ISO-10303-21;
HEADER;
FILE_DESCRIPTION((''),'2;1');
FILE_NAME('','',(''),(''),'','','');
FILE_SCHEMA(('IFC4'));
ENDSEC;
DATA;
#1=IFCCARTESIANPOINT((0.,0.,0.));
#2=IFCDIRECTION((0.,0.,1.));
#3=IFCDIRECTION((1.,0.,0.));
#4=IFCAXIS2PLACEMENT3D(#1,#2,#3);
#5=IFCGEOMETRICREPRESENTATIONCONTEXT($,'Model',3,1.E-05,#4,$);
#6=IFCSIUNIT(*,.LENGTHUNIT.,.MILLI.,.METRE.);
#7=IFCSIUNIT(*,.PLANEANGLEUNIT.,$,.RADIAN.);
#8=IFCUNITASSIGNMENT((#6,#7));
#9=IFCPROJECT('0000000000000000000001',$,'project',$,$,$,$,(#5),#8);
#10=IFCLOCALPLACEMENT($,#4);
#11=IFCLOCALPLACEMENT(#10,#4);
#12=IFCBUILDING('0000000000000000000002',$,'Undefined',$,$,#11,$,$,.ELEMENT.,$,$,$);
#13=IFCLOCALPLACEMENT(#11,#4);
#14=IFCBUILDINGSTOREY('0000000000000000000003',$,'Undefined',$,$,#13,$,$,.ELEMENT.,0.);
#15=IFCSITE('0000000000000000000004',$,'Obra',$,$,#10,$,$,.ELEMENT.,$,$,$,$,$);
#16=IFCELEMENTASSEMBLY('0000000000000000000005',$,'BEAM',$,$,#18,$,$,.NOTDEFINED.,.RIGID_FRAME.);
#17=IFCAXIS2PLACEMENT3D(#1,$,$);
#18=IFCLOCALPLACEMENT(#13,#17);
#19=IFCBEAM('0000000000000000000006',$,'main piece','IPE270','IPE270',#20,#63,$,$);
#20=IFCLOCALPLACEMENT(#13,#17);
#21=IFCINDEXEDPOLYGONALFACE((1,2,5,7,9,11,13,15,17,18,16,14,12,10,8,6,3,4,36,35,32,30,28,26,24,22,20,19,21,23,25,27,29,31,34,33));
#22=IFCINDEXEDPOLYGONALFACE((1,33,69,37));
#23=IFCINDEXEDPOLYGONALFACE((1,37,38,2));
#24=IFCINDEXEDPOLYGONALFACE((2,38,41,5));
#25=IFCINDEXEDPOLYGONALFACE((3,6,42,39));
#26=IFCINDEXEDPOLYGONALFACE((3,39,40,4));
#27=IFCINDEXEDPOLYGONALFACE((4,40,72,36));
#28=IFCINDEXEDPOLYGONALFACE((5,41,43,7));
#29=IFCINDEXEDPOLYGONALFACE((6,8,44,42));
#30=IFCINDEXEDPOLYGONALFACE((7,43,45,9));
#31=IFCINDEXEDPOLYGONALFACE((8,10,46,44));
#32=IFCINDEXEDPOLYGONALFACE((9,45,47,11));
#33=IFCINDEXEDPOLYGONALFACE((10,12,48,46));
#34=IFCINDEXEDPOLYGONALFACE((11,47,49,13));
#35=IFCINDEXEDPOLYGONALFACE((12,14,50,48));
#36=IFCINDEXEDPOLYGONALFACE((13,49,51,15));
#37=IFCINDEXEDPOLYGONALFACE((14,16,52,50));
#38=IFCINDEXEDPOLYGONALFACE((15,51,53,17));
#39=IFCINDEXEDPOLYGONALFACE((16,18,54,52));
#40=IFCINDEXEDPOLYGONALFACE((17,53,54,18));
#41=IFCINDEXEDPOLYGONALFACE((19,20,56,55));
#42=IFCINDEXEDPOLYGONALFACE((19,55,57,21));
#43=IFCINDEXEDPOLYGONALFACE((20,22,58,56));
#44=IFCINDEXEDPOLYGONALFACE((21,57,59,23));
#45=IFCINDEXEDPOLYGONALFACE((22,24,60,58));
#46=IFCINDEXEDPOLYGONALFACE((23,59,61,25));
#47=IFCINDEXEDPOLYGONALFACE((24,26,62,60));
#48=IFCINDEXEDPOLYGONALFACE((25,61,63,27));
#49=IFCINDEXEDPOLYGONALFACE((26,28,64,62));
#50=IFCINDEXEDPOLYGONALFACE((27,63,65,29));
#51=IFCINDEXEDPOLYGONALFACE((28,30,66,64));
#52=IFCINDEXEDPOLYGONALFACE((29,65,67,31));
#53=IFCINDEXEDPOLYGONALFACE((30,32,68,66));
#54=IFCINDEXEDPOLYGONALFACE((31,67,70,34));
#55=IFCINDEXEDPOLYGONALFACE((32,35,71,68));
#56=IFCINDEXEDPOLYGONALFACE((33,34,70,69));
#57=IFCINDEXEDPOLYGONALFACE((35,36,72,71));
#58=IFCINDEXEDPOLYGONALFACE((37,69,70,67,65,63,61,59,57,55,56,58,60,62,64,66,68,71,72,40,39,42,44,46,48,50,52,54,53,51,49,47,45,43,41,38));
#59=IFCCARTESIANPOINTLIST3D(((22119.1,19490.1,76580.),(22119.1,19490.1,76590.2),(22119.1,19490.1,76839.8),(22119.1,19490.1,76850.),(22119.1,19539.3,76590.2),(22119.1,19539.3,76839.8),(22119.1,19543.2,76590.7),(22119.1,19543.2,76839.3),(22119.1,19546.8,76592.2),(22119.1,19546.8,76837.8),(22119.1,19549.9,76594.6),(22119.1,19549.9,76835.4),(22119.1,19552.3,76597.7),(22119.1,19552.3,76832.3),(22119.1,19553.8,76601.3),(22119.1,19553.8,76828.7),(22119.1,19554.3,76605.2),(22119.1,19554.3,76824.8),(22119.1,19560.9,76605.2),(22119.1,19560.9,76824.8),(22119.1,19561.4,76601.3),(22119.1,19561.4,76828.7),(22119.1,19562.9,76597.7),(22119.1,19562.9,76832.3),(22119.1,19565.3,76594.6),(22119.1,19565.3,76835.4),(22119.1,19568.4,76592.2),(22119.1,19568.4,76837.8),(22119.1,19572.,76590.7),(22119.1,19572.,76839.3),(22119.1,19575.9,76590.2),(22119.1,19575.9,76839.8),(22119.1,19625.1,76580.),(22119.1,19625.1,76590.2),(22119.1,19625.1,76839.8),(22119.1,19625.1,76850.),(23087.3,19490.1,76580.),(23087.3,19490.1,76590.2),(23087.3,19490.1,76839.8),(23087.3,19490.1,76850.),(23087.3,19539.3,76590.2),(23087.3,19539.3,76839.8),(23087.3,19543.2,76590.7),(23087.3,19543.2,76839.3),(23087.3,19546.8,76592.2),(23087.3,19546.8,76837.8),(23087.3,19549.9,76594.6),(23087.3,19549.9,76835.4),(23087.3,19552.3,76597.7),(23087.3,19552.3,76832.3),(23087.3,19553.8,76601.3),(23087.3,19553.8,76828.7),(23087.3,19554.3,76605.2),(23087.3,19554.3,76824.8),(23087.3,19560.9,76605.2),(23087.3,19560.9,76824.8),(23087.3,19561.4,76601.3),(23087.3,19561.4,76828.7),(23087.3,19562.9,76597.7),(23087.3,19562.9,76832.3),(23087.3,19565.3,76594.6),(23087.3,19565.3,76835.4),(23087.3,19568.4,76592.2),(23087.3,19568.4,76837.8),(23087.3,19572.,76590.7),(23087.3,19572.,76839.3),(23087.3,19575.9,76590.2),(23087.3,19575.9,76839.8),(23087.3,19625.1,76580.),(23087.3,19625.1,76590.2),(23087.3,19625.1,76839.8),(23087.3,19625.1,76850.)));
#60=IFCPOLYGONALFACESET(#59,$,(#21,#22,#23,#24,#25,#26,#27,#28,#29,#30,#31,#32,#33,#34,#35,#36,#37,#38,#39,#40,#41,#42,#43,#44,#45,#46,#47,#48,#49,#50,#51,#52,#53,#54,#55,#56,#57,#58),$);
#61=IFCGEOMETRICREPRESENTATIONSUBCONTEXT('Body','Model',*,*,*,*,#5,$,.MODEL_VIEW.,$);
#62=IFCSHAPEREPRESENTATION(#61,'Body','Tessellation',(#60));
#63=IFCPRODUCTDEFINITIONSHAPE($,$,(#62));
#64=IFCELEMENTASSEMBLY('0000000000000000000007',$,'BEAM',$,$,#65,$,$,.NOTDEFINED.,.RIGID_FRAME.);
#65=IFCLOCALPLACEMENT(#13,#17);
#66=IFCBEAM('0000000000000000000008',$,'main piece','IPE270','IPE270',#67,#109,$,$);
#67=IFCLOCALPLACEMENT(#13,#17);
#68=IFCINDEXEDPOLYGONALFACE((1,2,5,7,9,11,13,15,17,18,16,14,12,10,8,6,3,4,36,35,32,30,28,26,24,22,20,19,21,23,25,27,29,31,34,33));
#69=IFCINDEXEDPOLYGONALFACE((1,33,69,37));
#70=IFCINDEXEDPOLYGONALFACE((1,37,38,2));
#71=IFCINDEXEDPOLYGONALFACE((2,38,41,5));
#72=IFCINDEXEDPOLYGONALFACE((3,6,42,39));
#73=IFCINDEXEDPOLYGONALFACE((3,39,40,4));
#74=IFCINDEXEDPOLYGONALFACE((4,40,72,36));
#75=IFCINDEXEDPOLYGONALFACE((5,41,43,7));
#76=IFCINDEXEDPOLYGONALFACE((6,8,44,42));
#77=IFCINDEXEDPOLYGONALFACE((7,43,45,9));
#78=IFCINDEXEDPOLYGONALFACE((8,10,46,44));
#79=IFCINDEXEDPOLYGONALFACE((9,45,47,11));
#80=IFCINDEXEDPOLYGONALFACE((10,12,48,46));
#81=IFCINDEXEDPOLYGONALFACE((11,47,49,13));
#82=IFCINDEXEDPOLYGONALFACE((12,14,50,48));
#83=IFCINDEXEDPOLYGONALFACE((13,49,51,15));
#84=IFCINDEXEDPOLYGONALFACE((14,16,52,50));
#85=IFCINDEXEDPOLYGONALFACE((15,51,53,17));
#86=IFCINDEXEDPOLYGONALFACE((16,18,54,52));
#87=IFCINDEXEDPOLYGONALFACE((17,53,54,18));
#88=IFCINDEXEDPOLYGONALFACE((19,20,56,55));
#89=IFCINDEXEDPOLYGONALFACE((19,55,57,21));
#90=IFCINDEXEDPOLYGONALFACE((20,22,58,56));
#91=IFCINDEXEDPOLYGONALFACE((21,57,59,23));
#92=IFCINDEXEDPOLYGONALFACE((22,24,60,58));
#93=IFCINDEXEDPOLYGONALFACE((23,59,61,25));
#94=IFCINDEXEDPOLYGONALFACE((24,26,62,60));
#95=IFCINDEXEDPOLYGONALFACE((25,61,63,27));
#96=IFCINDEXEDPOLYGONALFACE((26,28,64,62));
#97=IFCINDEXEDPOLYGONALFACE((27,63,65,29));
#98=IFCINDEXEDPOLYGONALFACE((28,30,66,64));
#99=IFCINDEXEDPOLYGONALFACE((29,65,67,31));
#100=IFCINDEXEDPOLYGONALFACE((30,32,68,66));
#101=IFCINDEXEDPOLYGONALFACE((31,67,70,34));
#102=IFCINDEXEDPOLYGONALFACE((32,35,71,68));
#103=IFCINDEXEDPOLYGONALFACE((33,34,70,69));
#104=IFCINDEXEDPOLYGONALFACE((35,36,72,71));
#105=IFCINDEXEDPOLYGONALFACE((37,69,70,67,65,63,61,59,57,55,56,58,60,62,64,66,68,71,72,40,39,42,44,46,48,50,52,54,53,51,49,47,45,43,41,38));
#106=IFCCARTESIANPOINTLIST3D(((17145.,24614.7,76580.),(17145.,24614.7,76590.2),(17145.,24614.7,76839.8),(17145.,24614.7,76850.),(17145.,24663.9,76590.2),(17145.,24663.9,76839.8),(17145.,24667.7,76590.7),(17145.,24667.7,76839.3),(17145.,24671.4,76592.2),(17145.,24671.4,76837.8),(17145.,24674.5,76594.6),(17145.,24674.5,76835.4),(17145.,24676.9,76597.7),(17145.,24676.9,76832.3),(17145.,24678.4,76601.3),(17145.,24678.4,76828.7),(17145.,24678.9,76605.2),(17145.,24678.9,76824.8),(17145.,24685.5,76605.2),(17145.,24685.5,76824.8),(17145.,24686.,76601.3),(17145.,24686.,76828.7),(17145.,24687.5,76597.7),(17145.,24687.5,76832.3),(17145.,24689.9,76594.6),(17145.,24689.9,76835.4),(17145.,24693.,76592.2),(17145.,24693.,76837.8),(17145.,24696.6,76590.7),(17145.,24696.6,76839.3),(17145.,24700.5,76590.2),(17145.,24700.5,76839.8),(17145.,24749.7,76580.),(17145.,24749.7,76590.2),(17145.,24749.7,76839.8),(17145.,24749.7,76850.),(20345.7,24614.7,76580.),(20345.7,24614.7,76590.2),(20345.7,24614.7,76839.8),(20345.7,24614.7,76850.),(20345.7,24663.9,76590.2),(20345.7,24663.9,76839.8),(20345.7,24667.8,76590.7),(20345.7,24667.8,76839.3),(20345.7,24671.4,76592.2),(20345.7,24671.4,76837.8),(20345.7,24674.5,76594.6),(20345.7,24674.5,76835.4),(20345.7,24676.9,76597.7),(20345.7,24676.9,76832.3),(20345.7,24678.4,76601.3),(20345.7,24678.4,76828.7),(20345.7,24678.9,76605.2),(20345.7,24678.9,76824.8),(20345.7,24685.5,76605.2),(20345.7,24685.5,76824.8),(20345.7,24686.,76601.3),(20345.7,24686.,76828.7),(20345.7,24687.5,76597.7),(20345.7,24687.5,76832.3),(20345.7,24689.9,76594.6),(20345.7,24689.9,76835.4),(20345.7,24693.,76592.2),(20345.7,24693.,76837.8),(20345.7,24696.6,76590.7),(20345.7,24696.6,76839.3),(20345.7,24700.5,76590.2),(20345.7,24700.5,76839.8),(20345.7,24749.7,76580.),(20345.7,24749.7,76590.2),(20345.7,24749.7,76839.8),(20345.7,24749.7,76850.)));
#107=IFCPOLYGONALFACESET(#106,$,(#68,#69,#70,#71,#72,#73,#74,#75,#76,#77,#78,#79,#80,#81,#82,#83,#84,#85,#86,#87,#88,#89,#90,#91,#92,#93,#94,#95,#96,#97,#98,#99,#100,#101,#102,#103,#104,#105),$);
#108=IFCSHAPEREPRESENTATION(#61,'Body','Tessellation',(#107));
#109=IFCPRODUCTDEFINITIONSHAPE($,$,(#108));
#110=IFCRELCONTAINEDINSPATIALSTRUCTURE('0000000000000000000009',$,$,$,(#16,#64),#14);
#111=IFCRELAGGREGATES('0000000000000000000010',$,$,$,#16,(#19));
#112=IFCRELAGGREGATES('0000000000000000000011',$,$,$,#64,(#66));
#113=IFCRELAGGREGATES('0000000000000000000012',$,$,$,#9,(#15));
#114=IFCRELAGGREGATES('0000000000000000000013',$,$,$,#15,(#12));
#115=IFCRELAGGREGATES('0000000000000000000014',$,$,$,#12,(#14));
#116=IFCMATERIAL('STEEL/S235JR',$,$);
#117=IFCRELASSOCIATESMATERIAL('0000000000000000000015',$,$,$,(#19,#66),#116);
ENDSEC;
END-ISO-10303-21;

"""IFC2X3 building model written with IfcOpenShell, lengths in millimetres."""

from ifc_helpers import new_model, si_unit, frame, origin_with_axes, origin_2d_with_axis, place, context, subcontext, project, spatial, i_section, extrude, material, element, aggregate, save


model = new_model("IFC2X3")

# Units and contexts
model_context = context("Model", 3, precision=1e-05, world=origin_with_axes())
body_context = subcontext(model_context, "Body", "Model", "MODEL_VIEW")
ifc_project = project(units=[si_unit("LENGTHUNIT", "METRE", prefix="MILLI"), si_unit("PLANEANGLEUNIT", "RADIAN")], contexts=[model_context])

# Site, building, storey
site_placement = place(None, origin_with_axes())
site = spatial("IfcSite", under=ifc_project, at=site_placement, Name="Obra", CompositionType="ELEMENT")
building_placement = place(site_placement, origin_with_axes())
building = spatial("IfcBuilding", under=site, at=building_placement, Name="Undefined", CompositionType="ELEMENT")
storey_placement = place(building_placement, origin_with_axes())
storey = spatial("IfcBuildingStorey", under=building, at=storey_placement, Name="Undefined", CompositionType="ELEMENT", Elevation=0.0)

# Element assemblies, beams
assembly_1_placement = place(storey_placement, origin_with_axes())
assembly_1 = element("IfcElementAssembly", 1, at=assembly_1_placement, inside=storey, Name="BEAM", AssemblyPlace="NOTDEFINED", PredefinedType="RIGID_FRAME")
ifc_material = material(Name="STEEL/S235JR")
beam_1_placement = place(assembly_1_placement, frame((22119.1, 19557.6, 76715.0), z_axis=(0.0, 0.0, 1.0), x_axis=(1.0, 0.0, 0.0)))
beam_1 = element("IfcBeam", 2, at=beam_1_placement, material=ifc_material, Name="main piece", Description="IPE270", ObjectType="IPE270", context=body_context, shape_type="SweptSolid", body=[
    extrude(i_section(OverallWidth=135.0, OverallDepth=270.0, WebThickness=6.6, FlangeThickness=10.2, FilletRadius=15.0, at=origin_2d_with_axis()), frame((968.2, 0.0, 0.0), z_axis=(-1.0, 0.0, 0.0), x_axis=(0.0, -1.0, 0.0)), (0.0, 0.0, 1.0), 968.2),
])
aggregate(assembly_1, [beam_1])
assembly_2_placement = place(storey_placement, origin_with_axes())
assembly_2 = element("IfcElementAssembly", 3, at=assembly_2_placement, inside=storey, Name="BEAM", AssemblyPlace="NOTDEFINED", PredefinedType="RIGID_FRAME")
beam_2_placement = place(assembly_2_placement, frame((17145.0, 24682.2, 76715.0), z_axis=(0.0, 0.0, 1.0), x_axis=(1.0, 0.000002, 0.0)))
beam_2 = element("IfcBeam", 4, at=beam_2_placement, material=ifc_material, Name="main piece", Description="IPE270", ObjectType="IPE270", context=body_context, shape_type="SweptSolid", body=[
    extrude(i_section(OverallWidth=135.0, OverallDepth=270.0, WebThickness=6.6, FlangeThickness=10.2, FilletRadius=15.0, at=origin_2d_with_axis()), frame((3200.7, 0.0, 0.0), z_axis=(-1.0, 0.0, 0.0), x_axis=(0.0, -1.0, 0.0)), (0.0, 0.0, 1.0), 3200.7),
])
aggregate(assembly_2, [beam_2])

save(model, "model.ifc")
